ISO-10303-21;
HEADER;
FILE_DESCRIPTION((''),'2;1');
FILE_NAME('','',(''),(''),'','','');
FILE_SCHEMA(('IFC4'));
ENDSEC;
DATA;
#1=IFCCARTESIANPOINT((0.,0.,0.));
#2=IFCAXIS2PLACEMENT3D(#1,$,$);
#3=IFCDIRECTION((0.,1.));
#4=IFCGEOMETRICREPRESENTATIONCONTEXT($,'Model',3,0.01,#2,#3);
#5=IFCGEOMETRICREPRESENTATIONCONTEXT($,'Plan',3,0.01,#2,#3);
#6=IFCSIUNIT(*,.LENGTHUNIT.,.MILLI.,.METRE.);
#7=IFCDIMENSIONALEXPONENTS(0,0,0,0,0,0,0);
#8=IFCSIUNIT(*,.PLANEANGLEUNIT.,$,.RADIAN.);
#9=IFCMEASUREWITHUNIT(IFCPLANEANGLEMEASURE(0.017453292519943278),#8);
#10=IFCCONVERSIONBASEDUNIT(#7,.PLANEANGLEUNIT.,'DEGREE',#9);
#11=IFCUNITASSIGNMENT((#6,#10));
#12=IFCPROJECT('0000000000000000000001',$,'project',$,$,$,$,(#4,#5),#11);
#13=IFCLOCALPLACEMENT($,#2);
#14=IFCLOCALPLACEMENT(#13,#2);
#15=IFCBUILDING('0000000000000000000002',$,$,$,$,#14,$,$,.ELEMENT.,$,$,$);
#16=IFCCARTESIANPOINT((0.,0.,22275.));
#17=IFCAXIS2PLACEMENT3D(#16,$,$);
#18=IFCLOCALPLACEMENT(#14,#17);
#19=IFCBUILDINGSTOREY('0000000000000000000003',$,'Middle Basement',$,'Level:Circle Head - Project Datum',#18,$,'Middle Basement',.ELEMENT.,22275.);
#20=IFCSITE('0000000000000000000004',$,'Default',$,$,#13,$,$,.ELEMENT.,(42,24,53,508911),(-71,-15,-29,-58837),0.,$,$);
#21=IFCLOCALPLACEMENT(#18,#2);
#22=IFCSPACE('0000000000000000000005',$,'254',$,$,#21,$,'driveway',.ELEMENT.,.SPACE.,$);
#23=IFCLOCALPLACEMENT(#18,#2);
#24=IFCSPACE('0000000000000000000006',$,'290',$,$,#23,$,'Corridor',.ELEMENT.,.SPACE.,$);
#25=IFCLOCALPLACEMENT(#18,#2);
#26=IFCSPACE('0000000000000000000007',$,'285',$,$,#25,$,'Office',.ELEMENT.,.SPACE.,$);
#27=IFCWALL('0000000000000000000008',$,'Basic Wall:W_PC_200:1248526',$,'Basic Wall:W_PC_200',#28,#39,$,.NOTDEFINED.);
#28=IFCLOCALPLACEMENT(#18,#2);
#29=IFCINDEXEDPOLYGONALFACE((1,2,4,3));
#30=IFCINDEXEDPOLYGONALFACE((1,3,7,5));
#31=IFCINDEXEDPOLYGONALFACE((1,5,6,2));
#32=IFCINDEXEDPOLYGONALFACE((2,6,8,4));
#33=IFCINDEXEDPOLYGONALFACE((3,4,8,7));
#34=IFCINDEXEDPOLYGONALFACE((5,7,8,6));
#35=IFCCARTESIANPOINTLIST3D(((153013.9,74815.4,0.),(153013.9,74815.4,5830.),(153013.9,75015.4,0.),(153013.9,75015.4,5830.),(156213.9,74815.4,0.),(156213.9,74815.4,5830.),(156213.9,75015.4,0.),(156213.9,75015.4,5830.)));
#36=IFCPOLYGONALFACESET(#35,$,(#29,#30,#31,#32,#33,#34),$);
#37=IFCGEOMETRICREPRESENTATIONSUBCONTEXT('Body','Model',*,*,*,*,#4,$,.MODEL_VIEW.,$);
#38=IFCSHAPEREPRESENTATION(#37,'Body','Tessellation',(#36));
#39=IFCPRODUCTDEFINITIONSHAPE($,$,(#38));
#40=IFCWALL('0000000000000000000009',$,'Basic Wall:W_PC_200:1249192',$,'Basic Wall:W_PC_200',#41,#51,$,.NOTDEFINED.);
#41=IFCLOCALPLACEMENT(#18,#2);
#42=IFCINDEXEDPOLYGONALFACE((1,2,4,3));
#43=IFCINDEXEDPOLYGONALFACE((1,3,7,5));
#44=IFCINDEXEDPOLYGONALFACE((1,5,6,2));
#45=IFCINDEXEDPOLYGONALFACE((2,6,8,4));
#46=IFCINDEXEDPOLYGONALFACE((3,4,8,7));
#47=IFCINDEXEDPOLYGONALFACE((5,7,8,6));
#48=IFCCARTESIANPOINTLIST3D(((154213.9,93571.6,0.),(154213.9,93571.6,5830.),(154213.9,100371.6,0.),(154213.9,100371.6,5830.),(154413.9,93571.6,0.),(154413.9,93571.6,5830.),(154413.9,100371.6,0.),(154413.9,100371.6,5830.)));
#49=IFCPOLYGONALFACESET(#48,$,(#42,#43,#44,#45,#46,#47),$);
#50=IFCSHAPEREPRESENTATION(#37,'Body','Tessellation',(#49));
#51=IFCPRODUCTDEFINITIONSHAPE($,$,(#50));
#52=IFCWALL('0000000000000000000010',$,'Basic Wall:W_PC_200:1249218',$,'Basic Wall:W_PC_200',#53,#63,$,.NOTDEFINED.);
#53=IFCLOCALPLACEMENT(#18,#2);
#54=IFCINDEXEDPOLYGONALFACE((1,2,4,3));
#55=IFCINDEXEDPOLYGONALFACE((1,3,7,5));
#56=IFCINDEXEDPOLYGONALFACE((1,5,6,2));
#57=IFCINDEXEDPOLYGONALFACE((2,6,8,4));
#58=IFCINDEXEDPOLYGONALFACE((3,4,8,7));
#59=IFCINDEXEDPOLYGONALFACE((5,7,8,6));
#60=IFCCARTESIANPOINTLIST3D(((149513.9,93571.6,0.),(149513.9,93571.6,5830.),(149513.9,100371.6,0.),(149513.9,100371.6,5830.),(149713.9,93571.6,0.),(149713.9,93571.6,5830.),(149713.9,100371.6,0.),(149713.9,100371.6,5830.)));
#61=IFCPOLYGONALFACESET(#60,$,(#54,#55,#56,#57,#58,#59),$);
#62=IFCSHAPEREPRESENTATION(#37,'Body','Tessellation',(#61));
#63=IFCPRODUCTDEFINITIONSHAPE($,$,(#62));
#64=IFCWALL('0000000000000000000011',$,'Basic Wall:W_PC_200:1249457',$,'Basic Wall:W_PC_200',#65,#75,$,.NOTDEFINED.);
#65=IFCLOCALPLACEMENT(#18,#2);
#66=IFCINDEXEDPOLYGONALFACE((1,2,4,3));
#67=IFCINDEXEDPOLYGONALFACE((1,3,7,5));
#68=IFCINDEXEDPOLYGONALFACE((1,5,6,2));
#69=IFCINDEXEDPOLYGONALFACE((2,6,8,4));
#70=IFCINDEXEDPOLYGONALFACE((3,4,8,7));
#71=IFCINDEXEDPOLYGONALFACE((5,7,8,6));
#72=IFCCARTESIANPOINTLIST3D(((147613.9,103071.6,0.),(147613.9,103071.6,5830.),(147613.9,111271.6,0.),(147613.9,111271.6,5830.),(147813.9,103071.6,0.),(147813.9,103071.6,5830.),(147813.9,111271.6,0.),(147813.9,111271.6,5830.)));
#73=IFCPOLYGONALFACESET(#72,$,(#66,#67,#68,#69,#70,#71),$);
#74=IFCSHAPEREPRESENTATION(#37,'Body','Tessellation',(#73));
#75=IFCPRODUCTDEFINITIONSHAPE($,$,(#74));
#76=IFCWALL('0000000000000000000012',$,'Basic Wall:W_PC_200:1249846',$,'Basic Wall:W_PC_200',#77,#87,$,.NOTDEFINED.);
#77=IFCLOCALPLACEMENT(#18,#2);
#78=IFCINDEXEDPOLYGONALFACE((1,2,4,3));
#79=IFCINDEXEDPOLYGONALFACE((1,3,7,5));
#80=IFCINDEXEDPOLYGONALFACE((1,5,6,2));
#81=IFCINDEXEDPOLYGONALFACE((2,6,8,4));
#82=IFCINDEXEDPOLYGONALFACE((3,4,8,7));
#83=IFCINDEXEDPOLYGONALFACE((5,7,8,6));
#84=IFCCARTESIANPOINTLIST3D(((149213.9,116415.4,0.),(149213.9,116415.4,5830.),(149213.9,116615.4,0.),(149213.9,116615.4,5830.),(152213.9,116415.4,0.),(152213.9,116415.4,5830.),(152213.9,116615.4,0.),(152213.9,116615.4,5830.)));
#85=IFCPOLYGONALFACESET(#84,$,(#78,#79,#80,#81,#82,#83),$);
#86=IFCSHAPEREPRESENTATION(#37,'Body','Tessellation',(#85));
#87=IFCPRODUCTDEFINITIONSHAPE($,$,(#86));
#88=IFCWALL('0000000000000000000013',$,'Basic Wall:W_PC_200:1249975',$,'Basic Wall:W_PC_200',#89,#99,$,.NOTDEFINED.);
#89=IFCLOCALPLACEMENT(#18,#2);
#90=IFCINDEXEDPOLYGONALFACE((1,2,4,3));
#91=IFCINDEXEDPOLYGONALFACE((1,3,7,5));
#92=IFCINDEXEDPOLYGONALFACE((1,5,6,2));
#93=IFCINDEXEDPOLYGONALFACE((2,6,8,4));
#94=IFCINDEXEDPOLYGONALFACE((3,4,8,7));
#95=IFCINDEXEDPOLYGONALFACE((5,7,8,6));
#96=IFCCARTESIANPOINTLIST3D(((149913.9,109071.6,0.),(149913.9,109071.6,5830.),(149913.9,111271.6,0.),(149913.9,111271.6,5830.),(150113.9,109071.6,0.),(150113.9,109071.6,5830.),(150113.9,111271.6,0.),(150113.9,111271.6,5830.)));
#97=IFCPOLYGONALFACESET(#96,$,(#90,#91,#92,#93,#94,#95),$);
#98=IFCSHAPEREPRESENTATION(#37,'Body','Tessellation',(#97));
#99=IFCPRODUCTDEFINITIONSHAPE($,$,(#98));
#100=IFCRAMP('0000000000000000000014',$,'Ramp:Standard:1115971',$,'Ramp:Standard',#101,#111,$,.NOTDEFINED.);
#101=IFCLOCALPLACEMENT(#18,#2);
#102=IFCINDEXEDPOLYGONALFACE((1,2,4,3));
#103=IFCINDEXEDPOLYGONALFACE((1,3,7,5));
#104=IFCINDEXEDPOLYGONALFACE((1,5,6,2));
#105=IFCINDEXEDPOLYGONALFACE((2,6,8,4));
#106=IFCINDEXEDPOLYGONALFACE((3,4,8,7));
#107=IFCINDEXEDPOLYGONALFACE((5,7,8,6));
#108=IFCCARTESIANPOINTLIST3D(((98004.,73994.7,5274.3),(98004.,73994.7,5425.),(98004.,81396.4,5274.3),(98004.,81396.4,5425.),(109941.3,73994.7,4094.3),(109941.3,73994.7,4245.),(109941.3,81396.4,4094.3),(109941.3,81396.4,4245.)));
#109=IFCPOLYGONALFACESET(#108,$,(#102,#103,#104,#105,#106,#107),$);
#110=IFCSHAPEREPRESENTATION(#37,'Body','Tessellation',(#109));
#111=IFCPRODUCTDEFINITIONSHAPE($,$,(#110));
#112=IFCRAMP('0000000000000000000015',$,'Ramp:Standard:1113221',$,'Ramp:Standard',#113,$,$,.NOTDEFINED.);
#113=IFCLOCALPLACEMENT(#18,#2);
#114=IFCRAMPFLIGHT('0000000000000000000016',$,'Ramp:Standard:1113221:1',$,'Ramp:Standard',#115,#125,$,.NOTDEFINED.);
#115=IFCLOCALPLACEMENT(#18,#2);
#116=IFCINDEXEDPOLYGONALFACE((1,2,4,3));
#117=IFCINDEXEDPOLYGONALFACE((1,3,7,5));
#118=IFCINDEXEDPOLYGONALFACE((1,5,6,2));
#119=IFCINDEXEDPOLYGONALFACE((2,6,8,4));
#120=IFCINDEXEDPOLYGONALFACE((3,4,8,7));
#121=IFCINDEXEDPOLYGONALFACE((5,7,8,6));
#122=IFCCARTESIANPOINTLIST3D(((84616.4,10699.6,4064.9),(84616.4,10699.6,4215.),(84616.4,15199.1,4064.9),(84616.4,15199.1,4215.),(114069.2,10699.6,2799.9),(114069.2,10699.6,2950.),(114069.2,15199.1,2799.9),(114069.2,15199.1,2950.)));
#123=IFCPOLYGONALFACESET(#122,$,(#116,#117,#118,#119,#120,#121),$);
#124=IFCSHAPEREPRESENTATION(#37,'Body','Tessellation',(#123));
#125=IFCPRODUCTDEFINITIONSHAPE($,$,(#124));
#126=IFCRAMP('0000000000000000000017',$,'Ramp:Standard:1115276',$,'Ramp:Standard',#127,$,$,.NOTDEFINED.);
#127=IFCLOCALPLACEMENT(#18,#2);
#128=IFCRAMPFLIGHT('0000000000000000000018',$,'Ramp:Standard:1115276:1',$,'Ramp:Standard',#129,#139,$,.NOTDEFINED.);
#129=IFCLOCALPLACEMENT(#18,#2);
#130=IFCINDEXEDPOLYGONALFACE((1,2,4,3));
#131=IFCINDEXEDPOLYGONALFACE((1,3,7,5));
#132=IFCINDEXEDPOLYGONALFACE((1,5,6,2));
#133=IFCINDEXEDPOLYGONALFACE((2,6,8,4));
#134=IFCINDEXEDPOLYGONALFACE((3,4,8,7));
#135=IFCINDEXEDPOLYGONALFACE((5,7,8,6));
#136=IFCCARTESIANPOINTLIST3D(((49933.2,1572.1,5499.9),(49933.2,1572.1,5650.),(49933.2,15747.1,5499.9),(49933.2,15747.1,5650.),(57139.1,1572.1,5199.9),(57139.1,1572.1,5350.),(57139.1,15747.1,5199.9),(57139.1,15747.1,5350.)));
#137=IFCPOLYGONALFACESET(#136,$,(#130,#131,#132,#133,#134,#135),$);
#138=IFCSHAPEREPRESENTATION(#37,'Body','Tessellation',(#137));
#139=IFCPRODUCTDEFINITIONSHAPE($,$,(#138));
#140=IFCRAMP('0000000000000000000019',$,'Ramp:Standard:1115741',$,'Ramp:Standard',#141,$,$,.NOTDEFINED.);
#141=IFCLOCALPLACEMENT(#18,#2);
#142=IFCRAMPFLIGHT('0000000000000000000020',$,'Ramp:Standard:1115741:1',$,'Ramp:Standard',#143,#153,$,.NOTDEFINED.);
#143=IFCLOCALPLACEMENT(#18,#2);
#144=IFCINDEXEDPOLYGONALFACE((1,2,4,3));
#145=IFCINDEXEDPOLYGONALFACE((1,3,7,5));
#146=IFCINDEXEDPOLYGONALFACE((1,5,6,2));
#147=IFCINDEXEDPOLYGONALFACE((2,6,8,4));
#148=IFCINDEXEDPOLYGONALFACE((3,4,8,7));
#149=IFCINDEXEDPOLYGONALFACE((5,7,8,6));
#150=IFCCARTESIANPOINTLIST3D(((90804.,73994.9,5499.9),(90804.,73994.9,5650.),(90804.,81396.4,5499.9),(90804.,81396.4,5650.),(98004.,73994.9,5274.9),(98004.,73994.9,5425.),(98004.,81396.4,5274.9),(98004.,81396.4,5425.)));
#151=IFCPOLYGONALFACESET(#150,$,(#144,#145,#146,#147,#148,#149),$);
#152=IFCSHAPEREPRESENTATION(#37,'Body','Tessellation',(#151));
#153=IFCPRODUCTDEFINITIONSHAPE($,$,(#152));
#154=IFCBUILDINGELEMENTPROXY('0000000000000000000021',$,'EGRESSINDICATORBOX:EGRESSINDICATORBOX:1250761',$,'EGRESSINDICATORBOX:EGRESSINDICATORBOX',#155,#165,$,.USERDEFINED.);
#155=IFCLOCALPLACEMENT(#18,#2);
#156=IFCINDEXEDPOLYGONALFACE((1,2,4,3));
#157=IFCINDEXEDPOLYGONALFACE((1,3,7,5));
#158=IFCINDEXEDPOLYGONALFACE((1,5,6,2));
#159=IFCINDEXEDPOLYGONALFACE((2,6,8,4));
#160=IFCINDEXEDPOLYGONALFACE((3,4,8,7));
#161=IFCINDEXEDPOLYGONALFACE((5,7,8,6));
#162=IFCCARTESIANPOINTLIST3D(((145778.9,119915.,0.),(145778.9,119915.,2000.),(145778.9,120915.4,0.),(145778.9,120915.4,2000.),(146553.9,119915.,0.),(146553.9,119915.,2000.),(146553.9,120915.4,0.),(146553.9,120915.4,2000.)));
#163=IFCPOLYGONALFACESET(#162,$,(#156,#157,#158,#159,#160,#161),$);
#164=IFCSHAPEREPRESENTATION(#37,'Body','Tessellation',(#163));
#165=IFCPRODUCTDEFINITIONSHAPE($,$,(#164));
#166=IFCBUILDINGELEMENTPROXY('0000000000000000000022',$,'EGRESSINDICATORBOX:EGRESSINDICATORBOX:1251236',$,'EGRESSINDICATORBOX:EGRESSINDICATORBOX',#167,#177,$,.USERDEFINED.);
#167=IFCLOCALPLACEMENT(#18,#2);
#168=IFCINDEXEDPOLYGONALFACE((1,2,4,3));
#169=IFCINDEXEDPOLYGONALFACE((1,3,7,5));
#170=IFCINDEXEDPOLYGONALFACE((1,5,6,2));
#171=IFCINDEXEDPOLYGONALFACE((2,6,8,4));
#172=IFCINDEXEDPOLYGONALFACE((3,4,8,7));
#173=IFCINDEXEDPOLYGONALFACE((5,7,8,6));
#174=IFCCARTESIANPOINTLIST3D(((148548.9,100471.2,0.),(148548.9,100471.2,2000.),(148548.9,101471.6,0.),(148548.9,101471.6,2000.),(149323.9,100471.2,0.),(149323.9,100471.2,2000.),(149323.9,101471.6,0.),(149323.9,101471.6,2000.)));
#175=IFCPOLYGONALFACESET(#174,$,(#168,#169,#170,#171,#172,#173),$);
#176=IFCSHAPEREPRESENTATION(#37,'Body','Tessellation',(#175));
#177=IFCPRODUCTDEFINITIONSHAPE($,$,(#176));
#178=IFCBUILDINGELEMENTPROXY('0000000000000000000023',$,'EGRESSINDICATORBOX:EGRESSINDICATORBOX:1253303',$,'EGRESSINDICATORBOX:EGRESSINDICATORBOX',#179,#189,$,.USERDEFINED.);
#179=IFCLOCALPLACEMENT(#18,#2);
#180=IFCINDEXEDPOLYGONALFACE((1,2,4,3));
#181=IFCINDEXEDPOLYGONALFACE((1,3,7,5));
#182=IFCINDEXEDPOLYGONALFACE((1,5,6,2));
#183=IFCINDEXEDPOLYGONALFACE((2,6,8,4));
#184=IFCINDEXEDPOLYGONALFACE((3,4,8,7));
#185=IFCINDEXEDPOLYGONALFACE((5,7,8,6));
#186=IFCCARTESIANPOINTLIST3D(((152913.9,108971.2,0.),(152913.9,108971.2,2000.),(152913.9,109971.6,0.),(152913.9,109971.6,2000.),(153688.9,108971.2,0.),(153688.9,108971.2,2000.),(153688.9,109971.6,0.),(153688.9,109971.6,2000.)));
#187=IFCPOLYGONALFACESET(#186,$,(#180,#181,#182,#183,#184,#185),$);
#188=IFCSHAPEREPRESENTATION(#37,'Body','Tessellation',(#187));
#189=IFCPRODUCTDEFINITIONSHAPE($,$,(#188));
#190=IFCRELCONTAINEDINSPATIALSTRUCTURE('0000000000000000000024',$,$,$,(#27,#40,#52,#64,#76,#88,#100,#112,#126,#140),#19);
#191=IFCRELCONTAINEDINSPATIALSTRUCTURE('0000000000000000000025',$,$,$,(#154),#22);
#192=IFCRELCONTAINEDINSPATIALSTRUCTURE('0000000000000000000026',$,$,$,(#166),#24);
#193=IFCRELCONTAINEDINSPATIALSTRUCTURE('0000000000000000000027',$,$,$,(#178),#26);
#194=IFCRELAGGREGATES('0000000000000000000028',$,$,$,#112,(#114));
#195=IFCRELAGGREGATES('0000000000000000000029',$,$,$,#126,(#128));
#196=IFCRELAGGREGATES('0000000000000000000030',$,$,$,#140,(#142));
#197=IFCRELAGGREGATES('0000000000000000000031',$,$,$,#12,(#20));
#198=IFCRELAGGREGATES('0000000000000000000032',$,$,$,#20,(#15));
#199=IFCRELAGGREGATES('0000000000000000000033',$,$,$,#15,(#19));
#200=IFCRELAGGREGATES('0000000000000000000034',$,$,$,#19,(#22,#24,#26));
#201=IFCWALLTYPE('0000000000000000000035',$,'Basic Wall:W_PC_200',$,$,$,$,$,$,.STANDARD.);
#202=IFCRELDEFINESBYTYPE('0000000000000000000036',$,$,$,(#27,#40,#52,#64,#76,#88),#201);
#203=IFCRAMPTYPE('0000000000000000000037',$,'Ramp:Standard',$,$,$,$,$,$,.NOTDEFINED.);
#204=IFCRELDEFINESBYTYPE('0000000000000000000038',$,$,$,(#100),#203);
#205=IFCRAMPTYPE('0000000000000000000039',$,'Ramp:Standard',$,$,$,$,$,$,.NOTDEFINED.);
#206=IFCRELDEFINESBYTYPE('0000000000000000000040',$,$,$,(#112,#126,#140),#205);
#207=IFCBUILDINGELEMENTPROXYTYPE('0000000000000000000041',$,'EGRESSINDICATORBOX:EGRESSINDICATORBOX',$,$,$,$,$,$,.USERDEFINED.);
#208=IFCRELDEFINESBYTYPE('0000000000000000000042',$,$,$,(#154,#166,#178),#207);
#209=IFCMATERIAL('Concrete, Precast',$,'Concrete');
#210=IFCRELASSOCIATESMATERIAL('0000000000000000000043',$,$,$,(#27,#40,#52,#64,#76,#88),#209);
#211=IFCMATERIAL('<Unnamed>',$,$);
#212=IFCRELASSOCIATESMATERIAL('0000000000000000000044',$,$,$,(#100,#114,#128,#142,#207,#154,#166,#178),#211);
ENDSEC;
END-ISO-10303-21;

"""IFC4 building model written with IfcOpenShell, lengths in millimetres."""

from ifc_helpers import new_model, entity, si_unit, converted_unit, direction, frame, origin, place, context, subcontext, project, spatial, indexed_curve, outline, extrude, source, transform, mapped, material, type_object, type_shapes, element, aggregate, save


model = new_model("IFC4")

# Units and contexts
model_context = context("Model", 3, precision=0.01, world=origin(), true_north=direction((0.0, 1.0)))
plan_context = context("Plan", 3, precision=0.01, world=origin(), true_north=direction((0.0, 1.0)))
body_context = subcontext(model_context, "Body", "Model", "MODEL_VIEW")
ifc_project = project(units=[si_unit("LENGTHUNIT", "METRE", prefix="MILLI"), converted_unit("PLANEANGLEUNIT", "DEGREE", entity("IfcPlaneAngleMeasure", 0.017453292519943278), si_unit("PLANEANGLEUNIT", "RADIAN"), dimensions=[0, 0, 0, 0, 0, 0, 0])], contexts=[model_context, plan_context])

# Site, building, storey
site_placement = place(None, origin())
site = spatial("IfcSite", under=ifc_project, at=site_placement, Name="Default", CompositionType="ELEMENT", RefLatitude=(42, 24, 53, 508911), RefLongitude=(-71, -15, -29, -58837), RefElevation=0.0)
building_placement = place(site_placement, origin())
building = spatial("IfcBuilding", under=site, at=building_placement, CompositionType="ELEMENT")
storey_placement = place(building_placement, frame((0.0, 0.0, 22275.0)))
storey = spatial("IfcBuildingStorey", under=building, at=storey_placement, Name="Middle Basement", ObjectType="Level:Circle Head - Project Datum", LongName="Middle Basement", CompositionType="ELEMENT", Elevation=22275.0)

# Shared definitions
ifc_material_1 = material(Name="Concrete, Precast", Category="Concrete")

# Walls
wall_type = type_object("IfcWallType", Name="Basic Wall:W_PC_200", PredefinedType="STANDARD")
wall_1_placement = place(storey_placement, frame((153013.9, 74915.4, 0.0)))
element("IfcWall", 1, at=wall_1_placement, inside=storey, type_object=wall_type, material=ifc_material_1, Name="Basic Wall:W_PC_200:1248526", ObjectType="Basic Wall:W_PC_200", PredefinedType="NOTDEFINED", context=body_context, shape_type="SweptSolid", body=[
    extrude(outline(indexed_curve([(3200.0, 100.0), (0.0, 100.0), (0.0, -100.0), (3200.0, -100.0), (3200.0, 100.0)], self_intersect=False)), origin(), (0.0, 0.0, 1.0), 5830.0),
])
for number, where, z_axis, x_axis, name in (
    (2, (154313.9, 93571.6, 0.0), (0.0, 0.0, 1.0), (0.0, 1.0, 0.0), "Basic Wall:W_PC_200:1249192"),
    (3, (149613.9, 93571.6, 0.0), (0.0, 0.0, 1.0), (0.0, 1.0, 0.0), "Basic Wall:W_PC_200:1249218"),
):
    element("IfcWall", number, at=place(storey_placement, frame(where, z_axis=z_axis, x_axis=x_axis)), inside=storey, type_object=wall_type, material=ifc_material_1, Name=name, ObjectType="Basic Wall:W_PC_200", PredefinedType="NOTDEFINED", context=body_context, shape_type="SweptSolid", body=[
        extrude(outline(indexed_curve([(6800.0, 100.0), (0.0, 100.0), (0.0, -100.0), (6800.0, -100.0), (6800.0, 100.0)], self_intersect=False)), origin(), (0.0, 0.0, 1.0), 5830.0),
    ])
wall_2_placement = place(storey_placement, frame((147713.9, 103071.6, 0.0), z_axis=(0.0, 0.0, 1.0), x_axis=(0.0, 1.0, 0.0)))
element("IfcWall", 4, at=wall_2_placement, inside=storey, type_object=wall_type, material=ifc_material_1, Name="Basic Wall:W_PC_200:1249457", ObjectType="Basic Wall:W_PC_200", PredefinedType="NOTDEFINED", context=body_context, shape_type="SweptSolid", body=[
    extrude(outline(indexed_curve([(8200.0, 100.0), (0.0, 100.0), (0.0, -100.0), (8200.0, -100.0), (8200.0, 100.0)], self_intersect=False)), origin(), (0.0, 0.0, 1.0), 5830.0),
])
wall_3_placement = place(storey_placement, frame((152213.9, 116515.4, 0.0), z_axis=(0.0, 0.0, 1.0), x_axis=(-1.0, 0.0, 0.0)))
element("IfcWall", 5, at=wall_3_placement, inside=storey, type_object=wall_type, material=ifc_material_1, Name="Basic Wall:W_PC_200:1249846", ObjectType="Basic Wall:W_PC_200", PredefinedType="NOTDEFINED", context=body_context, shape_type="SweptSolid", body=[
    extrude(outline(indexed_curve([(3000.0, 100.0), (0.0, 100.0), (0.0, -100.0), (3000.0, -100.0), (3000.0, 100.0)], self_intersect=False)), origin(), (0.0, 0.0, 1.0), 5830.0),
])
wall_4_placement = place(storey_placement, frame((150013.9, 109071.6, 0.0), z_axis=(0.0, 0.0, 1.0), x_axis=(0.0, 1.0, 0.0)))
element("IfcWall", 6, at=wall_4_placement, inside=storey, type_object=wall_type, material=ifc_material_1, Name="Basic Wall:W_PC_200:1249975", ObjectType="Basic Wall:W_PC_200", PredefinedType="NOTDEFINED", context=body_context, shape_type="SweptSolid", body=[
    extrude(outline(indexed_curve([(2200.0, 100.0), (0.0, 100.0), (0.0, -100.0), (2200.0, -100.0), (2200.0, 100.0)], self_intersect=False)), origin(), (0.0, 0.0, 1.0), 5830.0),
])

# Ramp
ifc_material_2 = material(Name="<Unnamed>")
ramp_type_1 = type_object("IfcRampType", Name="Ramp:Standard", PredefinedType="NOTDEFINED")
ramp_1_placement = place(storey_placement, origin())
element("IfcRamp", 7, at=ramp_1_placement, inside=storey, type_object=ramp_type_1, material=ifc_material_2, Name="Ramp:Standard:1115971", ObjectType="Ramp:Standard", PredefinedType="NOTDEFINED", context=body_context, shape_type="SweptSolid", body=[
    extrude(outline(indexed_curve([(514.6, -5968.7), (665.4, -5968.7), (-514.6, 5968.7), (-665.4, 5968.7), (514.6, -5968.7)], self_intersect=False)), frame((103972.7, 73994.7, 4759.6), z_axis=(0.0, 1.0, 0.0), x_axis=(0.0, 0.0, -1.0)), (0.0, 0.0, 1.0), 7401.7),
])

# Ramps, ramp flights
ramp_type_2 = type_object("IfcRampType", Name="Ramp:Standard", PredefinedType="NOTDEFINED")
ramp_2_placement = place(storey_placement, origin())
ramp_2 = element("IfcRamp", 8, at=ramp_2_placement, inside=storey, type_object=ramp_type_2, Name="Ramp:Standard:1113221", ObjectType="Ramp:Standard", PredefinedType="NOTDEFINED")
ramp_flight_1_placement = place(ramp_2_placement, origin())
ramp_flight_1 = element("IfcRampFlight", 9, at=ramp_flight_1_placement, material=ifc_material_2, Name="Ramp:Standard:1113221:1", ObjectType="Ramp:Standard", PredefinedType="NOTDEFINED", context=body_context, shape_type="SweptSolid", body=[
    extrude(outline(indexed_curve([(557.4, -14726.4), (707.6, -14726.4), (-557.4, 14726.4), (-707.6, 14726.4), (557.4, -14726.4)], self_intersect=False)), frame((99342.8, 10699.6, 3507.4), z_axis=(0.0, 1.0, 0.0), x_axis=(0.0, 0.0, -1.0)), (0.0, 0.0, 1.0), 4499.5),
])
aggregate(ramp_2, [ramp_flight_1])
ramp_3_placement = place(storey_placement, origin())
ramp_3 = element("IfcRamp", 10, at=ramp_3_placement, inside=storey, type_object=ramp_type_2, Name="Ramp:Standard:1115276", ObjectType="Ramp:Standard", PredefinedType="NOTDEFINED")
ramp_flight_2_placement = place(ramp_3_placement, origin())
ramp_flight_2 = element("IfcRampFlight", 11, at=ramp_flight_2_placement, material=ifc_material_2, Name="Ramp:Standard:1115276:1", ObjectType="Ramp:Standard", PredefinedType="NOTDEFINED", context=body_context, shape_type="SweptSolid", body=[
    extrude(outline(indexed_curve([(74.9, -3602.9), (225.1, -3602.9), (-74.9, 3602.9), (-225.1, 3602.9), (74.9, -3602.9)], self_intersect=False)), frame((53536.2, 1572.1, 5424.9), z_axis=(0.0, 1.0, 0.0), x_axis=(0.0, 0.0, -1.0)), (0.0, 0.0, 1.0), 14175.0),
])
aggregate(ramp_3, [ramp_flight_2])
ramp_4_placement = place(storey_placement, origin())
ramp_4 = element("IfcRamp", 12, at=ramp_4_placement, inside=storey, type_object=ramp_type_2, Name="Ramp:Standard:1115741", ObjectType="Ramp:Standard", PredefinedType="NOTDEFINED")
ramp_flight_3_placement = place(ramp_4_placement, origin())
ramp_flight_3 = element("IfcRampFlight", 13, at=ramp_flight_3_placement, material=ifc_material_2, Name="Ramp:Standard:1115741:1", ObjectType="Ramp:Standard", PredefinedType="NOTDEFINED", context=body_context, shape_type="SweptSolid", body=[
    extrude(outline(indexed_curve([(37.5, -3600.0), (187.5, -3600.0), (-37.5, 3600.0), (-187.5, 3600.0), (37.5, -3600.0)], self_intersect=False)), frame((94404.0, 73994.9, 5462.5), z_axis=(0.0, 1.0, 0.0), x_axis=(0.0, 0.0, -1.0)), (0.0, 0.0, 1.0), 7401.5),
])
aggregate(ramp_4, [ramp_flight_3])

# Shared definitions
space_1_placement = place(storey_placement, origin())
space_1 = spatial("IfcSpace", under=storey, at=space_1_placement, Name="254", LongName="driveway", CompositionType="ELEMENT", PredefinedType="SPACE")

# Building element proxy
building_element_proxy_type_1 = type_object("IfcBuildingElementProxyType", Name="EGRESSINDICATORBOX:EGRESSINDICATORBOX", PredefinedType="USERDEFINED", material=ifc_material_2)
shared_shape_1 = source(origin(), body_context, "Body", "SweptSolid", [
    extrude(outline(indexed_curve([(-387.5, -500.2), (387.5, -500.2), (387.5, 500.2), (-387.5, 500.2), (-387.5, -500.2)], self_intersect=False)), frame((0.0, 0.0, 0.0), z_axis=(0.0, 0.0, 1.0), x_axis=(-1.0, 0.0, 0.0)), (0.0, 0.0, 1.0), 2000.0),
])
type_shapes(building_element_proxy_type_1, [shared_shape_1])
proxy_1_placement = place(space_1_placement, frame((146166.4, 120415.2, 0.0)))
element("IfcBuildingElementProxy", 14, at=proxy_1_placement, inside=space_1, type_object=building_element_proxy_type_1, material=ifc_material_2, Name="EGRESSINDICATORBOX:EGRESSINDICATORBOX:1250761", ObjectType="EGRESSINDICATORBOX:EGRESSINDICATORBOX", PredefinedType="USERDEFINED", context=body_context, shape_type="MappedRepresentation", body=[
    mapped(shared_shape_1, transform((0.0, 0.0, 0.0), scale=1.0)),
])

# Shared definitions
space_2_placement = place(storey_placement, origin())
space_2 = spatial("IfcSpace", under=storey, at=space_2_placement, Name="290", LongName="Corridor", CompositionType="ELEMENT", PredefinedType="SPACE")

# Building element proxy
proxy_2_placement = place(space_2_placement, frame((148936.4, 100971.4, 0.0)))
element("IfcBuildingElementProxy", 15, at=proxy_2_placement, inside=space_2, type_object=building_element_proxy_type_1, material=ifc_material_2, Name="EGRESSINDICATORBOX:EGRESSINDICATORBOX:1251236", ObjectType="EGRESSINDICATORBOX:EGRESSINDICATORBOX", PredefinedType="USERDEFINED", context=body_context, shape_type="MappedRepresentation", body=[
    mapped(shared_shape_1, transform((0.0, 0.0, 0.0), scale=1.0)),
])

# Shared definitions
space_3_placement = place(storey_placement, origin())
space_3 = spatial("IfcSpace", under=storey, at=space_3_placement, Name="285", LongName="Office", CompositionType="ELEMENT", PredefinedType="SPACE")

# Building element proxy
proxy_3_placement = place(space_3_placement, frame((153301.4, 109471.4, 0.0)))
element("IfcBuildingElementProxy", 16, at=proxy_3_placement, inside=space_3, type_object=building_element_proxy_type_1, material=ifc_material_2, Name="EGRESSINDICATORBOX:EGRESSINDICATORBOX:1253303", ObjectType="EGRESSINDICATORBOX:EGRESSINDICATORBOX", PredefinedType="USERDEFINED", context=body_context, shape_type="MappedRepresentation", body=[
    mapped(shared_shape_1, transform((0.0, 0.0, 0.0), scale=1.0)),
])

save(model, "model.ifc")
